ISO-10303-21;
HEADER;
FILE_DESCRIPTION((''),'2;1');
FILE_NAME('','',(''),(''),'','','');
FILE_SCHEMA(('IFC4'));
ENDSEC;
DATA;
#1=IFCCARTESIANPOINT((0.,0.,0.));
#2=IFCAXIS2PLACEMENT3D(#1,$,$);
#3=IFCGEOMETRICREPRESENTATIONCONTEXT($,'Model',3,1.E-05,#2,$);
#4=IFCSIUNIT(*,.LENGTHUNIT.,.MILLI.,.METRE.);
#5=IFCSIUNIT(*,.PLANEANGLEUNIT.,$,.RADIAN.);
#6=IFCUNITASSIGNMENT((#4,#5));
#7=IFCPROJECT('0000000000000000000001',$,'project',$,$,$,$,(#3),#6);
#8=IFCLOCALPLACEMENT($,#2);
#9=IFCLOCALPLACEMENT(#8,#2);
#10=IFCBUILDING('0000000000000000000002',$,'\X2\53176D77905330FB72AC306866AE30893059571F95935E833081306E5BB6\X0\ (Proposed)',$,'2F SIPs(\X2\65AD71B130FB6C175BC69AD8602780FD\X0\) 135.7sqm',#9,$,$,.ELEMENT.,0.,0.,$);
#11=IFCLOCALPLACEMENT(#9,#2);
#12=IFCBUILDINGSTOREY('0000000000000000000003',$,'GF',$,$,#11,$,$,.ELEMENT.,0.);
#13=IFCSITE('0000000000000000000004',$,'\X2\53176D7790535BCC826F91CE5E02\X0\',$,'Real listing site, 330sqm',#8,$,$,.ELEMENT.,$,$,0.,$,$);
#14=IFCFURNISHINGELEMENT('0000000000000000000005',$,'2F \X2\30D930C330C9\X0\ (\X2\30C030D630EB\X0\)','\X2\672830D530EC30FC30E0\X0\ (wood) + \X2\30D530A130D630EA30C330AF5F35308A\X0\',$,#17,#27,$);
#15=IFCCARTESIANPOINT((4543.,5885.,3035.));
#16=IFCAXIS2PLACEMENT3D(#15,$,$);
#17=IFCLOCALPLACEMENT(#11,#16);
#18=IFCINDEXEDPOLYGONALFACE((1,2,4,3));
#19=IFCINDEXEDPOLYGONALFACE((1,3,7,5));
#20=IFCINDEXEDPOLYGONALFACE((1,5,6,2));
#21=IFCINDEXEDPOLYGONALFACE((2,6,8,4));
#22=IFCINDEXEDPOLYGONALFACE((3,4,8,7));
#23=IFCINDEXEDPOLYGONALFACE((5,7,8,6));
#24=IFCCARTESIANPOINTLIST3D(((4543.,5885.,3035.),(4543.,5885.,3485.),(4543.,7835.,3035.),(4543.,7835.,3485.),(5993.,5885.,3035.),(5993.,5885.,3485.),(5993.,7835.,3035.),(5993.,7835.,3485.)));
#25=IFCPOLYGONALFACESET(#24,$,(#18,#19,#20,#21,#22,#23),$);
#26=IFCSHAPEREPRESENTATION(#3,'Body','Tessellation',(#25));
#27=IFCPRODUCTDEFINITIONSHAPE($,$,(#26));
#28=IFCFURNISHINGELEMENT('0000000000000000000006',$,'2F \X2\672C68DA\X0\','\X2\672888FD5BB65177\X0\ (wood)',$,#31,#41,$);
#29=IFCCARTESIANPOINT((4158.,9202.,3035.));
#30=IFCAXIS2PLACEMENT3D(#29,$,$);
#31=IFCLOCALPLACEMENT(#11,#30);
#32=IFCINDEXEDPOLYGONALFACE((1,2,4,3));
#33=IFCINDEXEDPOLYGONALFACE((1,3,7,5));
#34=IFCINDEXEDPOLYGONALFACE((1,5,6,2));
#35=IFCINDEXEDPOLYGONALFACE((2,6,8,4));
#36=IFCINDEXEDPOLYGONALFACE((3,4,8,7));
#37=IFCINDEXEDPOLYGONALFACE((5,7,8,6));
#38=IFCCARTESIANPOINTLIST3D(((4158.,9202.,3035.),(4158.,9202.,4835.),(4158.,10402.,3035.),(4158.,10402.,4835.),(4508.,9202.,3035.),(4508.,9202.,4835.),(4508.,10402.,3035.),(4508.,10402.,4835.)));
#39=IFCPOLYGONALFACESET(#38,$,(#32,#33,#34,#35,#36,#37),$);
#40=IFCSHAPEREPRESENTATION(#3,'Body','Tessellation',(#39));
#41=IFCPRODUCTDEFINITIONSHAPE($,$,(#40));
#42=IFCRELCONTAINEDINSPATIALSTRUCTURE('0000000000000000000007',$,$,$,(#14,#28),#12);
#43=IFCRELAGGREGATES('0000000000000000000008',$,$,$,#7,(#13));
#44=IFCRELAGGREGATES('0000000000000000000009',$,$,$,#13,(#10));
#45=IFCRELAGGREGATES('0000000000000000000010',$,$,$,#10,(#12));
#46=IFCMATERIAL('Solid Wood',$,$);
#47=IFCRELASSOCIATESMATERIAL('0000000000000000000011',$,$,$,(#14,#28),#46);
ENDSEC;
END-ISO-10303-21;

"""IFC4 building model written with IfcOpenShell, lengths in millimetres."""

from ifc_helpers import new_model, si_unit, frame, frame_2d, origin, place, context, project, spatial, rectangle, extrude, material, element, save


model = new_model("IFC4")

# Units and contexts
model_context = context("Model", 3, precision=1e-05, world=origin())
ifc_project = project(units=[si_unit("LENGTHUNIT", "METRE", prefix="MILLI"), si_unit("PLANEANGLEUNIT", "RADIAN")], contexts=[model_context])

# Site, building, storey
site_placement = place(None, origin())
site = spatial("IfcSite", under=ifc_project, at=site_placement, Name="北海道富良野市", ObjectType="Real listing site, 330sqm", CompositionType="ELEMENT", RefElevation=0.0)
building_placement = place(site_placement, origin())
building = spatial("IfcBuilding", under=site, at=building_placement, Name="北海道・犬と暮らす土間広めの家 (Proposed)", ObjectType="2F SIPs(断熱・気密高性能) 135.7sqm", CompositionType="ELEMENT", ElevationOfRefHeight=0.0, ElevationOfTerrain=0.0)
storey_placement = place(building_placement, origin())
storey = spatial("IfcBuildingStorey", under=building, at=storey_placement, Name="GF", CompositionType="ELEMENT", Elevation=0.0)

# Shared definitions
ifc_material_1 = material(Name="Solid Wood")

# Furnishing elements
furnishing_1_placement = place(storey_placement, frame((4543.0, 5885.0, 3035.0)))
element("IfcFurnishingElement", 1, at=furnishing_1_placement, inside=storey, material=ifc_material_1, Name="2F ベッド (ダブル)", Description="木フレーム (wood) + ファブリック張り", context=model_context, shape_type="SweptSolid", body=[
    extrude(rectangle(XDim=1450.0, YDim=1950.0, at=frame_2d((725.0, 975.0))), frame((4543.0, 5885.0, 3035.0)), (0.0, 0.0, 1.0), 450.0),
])
furnishing_2_placement = place(storey_placement, frame((4158.0, 9202.0, 3035.0)))
element("IfcFurnishingElement", 2, at=furnishing_2_placement, inside=storey, material=ifc_material_1, Name="2F 本棚", Description="木製家具 (wood)", context=model_context, shape_type="SweptSolid", body=[
    extrude(rectangle(XDim=350.0, YDim=1200.0, at=frame_2d((175.0, 600.0))), frame((4158.0, 9202.0, 3035.0)), (0.0, 0.0, 1.0), 1800.0),
])

save(model, "model.ifc")
